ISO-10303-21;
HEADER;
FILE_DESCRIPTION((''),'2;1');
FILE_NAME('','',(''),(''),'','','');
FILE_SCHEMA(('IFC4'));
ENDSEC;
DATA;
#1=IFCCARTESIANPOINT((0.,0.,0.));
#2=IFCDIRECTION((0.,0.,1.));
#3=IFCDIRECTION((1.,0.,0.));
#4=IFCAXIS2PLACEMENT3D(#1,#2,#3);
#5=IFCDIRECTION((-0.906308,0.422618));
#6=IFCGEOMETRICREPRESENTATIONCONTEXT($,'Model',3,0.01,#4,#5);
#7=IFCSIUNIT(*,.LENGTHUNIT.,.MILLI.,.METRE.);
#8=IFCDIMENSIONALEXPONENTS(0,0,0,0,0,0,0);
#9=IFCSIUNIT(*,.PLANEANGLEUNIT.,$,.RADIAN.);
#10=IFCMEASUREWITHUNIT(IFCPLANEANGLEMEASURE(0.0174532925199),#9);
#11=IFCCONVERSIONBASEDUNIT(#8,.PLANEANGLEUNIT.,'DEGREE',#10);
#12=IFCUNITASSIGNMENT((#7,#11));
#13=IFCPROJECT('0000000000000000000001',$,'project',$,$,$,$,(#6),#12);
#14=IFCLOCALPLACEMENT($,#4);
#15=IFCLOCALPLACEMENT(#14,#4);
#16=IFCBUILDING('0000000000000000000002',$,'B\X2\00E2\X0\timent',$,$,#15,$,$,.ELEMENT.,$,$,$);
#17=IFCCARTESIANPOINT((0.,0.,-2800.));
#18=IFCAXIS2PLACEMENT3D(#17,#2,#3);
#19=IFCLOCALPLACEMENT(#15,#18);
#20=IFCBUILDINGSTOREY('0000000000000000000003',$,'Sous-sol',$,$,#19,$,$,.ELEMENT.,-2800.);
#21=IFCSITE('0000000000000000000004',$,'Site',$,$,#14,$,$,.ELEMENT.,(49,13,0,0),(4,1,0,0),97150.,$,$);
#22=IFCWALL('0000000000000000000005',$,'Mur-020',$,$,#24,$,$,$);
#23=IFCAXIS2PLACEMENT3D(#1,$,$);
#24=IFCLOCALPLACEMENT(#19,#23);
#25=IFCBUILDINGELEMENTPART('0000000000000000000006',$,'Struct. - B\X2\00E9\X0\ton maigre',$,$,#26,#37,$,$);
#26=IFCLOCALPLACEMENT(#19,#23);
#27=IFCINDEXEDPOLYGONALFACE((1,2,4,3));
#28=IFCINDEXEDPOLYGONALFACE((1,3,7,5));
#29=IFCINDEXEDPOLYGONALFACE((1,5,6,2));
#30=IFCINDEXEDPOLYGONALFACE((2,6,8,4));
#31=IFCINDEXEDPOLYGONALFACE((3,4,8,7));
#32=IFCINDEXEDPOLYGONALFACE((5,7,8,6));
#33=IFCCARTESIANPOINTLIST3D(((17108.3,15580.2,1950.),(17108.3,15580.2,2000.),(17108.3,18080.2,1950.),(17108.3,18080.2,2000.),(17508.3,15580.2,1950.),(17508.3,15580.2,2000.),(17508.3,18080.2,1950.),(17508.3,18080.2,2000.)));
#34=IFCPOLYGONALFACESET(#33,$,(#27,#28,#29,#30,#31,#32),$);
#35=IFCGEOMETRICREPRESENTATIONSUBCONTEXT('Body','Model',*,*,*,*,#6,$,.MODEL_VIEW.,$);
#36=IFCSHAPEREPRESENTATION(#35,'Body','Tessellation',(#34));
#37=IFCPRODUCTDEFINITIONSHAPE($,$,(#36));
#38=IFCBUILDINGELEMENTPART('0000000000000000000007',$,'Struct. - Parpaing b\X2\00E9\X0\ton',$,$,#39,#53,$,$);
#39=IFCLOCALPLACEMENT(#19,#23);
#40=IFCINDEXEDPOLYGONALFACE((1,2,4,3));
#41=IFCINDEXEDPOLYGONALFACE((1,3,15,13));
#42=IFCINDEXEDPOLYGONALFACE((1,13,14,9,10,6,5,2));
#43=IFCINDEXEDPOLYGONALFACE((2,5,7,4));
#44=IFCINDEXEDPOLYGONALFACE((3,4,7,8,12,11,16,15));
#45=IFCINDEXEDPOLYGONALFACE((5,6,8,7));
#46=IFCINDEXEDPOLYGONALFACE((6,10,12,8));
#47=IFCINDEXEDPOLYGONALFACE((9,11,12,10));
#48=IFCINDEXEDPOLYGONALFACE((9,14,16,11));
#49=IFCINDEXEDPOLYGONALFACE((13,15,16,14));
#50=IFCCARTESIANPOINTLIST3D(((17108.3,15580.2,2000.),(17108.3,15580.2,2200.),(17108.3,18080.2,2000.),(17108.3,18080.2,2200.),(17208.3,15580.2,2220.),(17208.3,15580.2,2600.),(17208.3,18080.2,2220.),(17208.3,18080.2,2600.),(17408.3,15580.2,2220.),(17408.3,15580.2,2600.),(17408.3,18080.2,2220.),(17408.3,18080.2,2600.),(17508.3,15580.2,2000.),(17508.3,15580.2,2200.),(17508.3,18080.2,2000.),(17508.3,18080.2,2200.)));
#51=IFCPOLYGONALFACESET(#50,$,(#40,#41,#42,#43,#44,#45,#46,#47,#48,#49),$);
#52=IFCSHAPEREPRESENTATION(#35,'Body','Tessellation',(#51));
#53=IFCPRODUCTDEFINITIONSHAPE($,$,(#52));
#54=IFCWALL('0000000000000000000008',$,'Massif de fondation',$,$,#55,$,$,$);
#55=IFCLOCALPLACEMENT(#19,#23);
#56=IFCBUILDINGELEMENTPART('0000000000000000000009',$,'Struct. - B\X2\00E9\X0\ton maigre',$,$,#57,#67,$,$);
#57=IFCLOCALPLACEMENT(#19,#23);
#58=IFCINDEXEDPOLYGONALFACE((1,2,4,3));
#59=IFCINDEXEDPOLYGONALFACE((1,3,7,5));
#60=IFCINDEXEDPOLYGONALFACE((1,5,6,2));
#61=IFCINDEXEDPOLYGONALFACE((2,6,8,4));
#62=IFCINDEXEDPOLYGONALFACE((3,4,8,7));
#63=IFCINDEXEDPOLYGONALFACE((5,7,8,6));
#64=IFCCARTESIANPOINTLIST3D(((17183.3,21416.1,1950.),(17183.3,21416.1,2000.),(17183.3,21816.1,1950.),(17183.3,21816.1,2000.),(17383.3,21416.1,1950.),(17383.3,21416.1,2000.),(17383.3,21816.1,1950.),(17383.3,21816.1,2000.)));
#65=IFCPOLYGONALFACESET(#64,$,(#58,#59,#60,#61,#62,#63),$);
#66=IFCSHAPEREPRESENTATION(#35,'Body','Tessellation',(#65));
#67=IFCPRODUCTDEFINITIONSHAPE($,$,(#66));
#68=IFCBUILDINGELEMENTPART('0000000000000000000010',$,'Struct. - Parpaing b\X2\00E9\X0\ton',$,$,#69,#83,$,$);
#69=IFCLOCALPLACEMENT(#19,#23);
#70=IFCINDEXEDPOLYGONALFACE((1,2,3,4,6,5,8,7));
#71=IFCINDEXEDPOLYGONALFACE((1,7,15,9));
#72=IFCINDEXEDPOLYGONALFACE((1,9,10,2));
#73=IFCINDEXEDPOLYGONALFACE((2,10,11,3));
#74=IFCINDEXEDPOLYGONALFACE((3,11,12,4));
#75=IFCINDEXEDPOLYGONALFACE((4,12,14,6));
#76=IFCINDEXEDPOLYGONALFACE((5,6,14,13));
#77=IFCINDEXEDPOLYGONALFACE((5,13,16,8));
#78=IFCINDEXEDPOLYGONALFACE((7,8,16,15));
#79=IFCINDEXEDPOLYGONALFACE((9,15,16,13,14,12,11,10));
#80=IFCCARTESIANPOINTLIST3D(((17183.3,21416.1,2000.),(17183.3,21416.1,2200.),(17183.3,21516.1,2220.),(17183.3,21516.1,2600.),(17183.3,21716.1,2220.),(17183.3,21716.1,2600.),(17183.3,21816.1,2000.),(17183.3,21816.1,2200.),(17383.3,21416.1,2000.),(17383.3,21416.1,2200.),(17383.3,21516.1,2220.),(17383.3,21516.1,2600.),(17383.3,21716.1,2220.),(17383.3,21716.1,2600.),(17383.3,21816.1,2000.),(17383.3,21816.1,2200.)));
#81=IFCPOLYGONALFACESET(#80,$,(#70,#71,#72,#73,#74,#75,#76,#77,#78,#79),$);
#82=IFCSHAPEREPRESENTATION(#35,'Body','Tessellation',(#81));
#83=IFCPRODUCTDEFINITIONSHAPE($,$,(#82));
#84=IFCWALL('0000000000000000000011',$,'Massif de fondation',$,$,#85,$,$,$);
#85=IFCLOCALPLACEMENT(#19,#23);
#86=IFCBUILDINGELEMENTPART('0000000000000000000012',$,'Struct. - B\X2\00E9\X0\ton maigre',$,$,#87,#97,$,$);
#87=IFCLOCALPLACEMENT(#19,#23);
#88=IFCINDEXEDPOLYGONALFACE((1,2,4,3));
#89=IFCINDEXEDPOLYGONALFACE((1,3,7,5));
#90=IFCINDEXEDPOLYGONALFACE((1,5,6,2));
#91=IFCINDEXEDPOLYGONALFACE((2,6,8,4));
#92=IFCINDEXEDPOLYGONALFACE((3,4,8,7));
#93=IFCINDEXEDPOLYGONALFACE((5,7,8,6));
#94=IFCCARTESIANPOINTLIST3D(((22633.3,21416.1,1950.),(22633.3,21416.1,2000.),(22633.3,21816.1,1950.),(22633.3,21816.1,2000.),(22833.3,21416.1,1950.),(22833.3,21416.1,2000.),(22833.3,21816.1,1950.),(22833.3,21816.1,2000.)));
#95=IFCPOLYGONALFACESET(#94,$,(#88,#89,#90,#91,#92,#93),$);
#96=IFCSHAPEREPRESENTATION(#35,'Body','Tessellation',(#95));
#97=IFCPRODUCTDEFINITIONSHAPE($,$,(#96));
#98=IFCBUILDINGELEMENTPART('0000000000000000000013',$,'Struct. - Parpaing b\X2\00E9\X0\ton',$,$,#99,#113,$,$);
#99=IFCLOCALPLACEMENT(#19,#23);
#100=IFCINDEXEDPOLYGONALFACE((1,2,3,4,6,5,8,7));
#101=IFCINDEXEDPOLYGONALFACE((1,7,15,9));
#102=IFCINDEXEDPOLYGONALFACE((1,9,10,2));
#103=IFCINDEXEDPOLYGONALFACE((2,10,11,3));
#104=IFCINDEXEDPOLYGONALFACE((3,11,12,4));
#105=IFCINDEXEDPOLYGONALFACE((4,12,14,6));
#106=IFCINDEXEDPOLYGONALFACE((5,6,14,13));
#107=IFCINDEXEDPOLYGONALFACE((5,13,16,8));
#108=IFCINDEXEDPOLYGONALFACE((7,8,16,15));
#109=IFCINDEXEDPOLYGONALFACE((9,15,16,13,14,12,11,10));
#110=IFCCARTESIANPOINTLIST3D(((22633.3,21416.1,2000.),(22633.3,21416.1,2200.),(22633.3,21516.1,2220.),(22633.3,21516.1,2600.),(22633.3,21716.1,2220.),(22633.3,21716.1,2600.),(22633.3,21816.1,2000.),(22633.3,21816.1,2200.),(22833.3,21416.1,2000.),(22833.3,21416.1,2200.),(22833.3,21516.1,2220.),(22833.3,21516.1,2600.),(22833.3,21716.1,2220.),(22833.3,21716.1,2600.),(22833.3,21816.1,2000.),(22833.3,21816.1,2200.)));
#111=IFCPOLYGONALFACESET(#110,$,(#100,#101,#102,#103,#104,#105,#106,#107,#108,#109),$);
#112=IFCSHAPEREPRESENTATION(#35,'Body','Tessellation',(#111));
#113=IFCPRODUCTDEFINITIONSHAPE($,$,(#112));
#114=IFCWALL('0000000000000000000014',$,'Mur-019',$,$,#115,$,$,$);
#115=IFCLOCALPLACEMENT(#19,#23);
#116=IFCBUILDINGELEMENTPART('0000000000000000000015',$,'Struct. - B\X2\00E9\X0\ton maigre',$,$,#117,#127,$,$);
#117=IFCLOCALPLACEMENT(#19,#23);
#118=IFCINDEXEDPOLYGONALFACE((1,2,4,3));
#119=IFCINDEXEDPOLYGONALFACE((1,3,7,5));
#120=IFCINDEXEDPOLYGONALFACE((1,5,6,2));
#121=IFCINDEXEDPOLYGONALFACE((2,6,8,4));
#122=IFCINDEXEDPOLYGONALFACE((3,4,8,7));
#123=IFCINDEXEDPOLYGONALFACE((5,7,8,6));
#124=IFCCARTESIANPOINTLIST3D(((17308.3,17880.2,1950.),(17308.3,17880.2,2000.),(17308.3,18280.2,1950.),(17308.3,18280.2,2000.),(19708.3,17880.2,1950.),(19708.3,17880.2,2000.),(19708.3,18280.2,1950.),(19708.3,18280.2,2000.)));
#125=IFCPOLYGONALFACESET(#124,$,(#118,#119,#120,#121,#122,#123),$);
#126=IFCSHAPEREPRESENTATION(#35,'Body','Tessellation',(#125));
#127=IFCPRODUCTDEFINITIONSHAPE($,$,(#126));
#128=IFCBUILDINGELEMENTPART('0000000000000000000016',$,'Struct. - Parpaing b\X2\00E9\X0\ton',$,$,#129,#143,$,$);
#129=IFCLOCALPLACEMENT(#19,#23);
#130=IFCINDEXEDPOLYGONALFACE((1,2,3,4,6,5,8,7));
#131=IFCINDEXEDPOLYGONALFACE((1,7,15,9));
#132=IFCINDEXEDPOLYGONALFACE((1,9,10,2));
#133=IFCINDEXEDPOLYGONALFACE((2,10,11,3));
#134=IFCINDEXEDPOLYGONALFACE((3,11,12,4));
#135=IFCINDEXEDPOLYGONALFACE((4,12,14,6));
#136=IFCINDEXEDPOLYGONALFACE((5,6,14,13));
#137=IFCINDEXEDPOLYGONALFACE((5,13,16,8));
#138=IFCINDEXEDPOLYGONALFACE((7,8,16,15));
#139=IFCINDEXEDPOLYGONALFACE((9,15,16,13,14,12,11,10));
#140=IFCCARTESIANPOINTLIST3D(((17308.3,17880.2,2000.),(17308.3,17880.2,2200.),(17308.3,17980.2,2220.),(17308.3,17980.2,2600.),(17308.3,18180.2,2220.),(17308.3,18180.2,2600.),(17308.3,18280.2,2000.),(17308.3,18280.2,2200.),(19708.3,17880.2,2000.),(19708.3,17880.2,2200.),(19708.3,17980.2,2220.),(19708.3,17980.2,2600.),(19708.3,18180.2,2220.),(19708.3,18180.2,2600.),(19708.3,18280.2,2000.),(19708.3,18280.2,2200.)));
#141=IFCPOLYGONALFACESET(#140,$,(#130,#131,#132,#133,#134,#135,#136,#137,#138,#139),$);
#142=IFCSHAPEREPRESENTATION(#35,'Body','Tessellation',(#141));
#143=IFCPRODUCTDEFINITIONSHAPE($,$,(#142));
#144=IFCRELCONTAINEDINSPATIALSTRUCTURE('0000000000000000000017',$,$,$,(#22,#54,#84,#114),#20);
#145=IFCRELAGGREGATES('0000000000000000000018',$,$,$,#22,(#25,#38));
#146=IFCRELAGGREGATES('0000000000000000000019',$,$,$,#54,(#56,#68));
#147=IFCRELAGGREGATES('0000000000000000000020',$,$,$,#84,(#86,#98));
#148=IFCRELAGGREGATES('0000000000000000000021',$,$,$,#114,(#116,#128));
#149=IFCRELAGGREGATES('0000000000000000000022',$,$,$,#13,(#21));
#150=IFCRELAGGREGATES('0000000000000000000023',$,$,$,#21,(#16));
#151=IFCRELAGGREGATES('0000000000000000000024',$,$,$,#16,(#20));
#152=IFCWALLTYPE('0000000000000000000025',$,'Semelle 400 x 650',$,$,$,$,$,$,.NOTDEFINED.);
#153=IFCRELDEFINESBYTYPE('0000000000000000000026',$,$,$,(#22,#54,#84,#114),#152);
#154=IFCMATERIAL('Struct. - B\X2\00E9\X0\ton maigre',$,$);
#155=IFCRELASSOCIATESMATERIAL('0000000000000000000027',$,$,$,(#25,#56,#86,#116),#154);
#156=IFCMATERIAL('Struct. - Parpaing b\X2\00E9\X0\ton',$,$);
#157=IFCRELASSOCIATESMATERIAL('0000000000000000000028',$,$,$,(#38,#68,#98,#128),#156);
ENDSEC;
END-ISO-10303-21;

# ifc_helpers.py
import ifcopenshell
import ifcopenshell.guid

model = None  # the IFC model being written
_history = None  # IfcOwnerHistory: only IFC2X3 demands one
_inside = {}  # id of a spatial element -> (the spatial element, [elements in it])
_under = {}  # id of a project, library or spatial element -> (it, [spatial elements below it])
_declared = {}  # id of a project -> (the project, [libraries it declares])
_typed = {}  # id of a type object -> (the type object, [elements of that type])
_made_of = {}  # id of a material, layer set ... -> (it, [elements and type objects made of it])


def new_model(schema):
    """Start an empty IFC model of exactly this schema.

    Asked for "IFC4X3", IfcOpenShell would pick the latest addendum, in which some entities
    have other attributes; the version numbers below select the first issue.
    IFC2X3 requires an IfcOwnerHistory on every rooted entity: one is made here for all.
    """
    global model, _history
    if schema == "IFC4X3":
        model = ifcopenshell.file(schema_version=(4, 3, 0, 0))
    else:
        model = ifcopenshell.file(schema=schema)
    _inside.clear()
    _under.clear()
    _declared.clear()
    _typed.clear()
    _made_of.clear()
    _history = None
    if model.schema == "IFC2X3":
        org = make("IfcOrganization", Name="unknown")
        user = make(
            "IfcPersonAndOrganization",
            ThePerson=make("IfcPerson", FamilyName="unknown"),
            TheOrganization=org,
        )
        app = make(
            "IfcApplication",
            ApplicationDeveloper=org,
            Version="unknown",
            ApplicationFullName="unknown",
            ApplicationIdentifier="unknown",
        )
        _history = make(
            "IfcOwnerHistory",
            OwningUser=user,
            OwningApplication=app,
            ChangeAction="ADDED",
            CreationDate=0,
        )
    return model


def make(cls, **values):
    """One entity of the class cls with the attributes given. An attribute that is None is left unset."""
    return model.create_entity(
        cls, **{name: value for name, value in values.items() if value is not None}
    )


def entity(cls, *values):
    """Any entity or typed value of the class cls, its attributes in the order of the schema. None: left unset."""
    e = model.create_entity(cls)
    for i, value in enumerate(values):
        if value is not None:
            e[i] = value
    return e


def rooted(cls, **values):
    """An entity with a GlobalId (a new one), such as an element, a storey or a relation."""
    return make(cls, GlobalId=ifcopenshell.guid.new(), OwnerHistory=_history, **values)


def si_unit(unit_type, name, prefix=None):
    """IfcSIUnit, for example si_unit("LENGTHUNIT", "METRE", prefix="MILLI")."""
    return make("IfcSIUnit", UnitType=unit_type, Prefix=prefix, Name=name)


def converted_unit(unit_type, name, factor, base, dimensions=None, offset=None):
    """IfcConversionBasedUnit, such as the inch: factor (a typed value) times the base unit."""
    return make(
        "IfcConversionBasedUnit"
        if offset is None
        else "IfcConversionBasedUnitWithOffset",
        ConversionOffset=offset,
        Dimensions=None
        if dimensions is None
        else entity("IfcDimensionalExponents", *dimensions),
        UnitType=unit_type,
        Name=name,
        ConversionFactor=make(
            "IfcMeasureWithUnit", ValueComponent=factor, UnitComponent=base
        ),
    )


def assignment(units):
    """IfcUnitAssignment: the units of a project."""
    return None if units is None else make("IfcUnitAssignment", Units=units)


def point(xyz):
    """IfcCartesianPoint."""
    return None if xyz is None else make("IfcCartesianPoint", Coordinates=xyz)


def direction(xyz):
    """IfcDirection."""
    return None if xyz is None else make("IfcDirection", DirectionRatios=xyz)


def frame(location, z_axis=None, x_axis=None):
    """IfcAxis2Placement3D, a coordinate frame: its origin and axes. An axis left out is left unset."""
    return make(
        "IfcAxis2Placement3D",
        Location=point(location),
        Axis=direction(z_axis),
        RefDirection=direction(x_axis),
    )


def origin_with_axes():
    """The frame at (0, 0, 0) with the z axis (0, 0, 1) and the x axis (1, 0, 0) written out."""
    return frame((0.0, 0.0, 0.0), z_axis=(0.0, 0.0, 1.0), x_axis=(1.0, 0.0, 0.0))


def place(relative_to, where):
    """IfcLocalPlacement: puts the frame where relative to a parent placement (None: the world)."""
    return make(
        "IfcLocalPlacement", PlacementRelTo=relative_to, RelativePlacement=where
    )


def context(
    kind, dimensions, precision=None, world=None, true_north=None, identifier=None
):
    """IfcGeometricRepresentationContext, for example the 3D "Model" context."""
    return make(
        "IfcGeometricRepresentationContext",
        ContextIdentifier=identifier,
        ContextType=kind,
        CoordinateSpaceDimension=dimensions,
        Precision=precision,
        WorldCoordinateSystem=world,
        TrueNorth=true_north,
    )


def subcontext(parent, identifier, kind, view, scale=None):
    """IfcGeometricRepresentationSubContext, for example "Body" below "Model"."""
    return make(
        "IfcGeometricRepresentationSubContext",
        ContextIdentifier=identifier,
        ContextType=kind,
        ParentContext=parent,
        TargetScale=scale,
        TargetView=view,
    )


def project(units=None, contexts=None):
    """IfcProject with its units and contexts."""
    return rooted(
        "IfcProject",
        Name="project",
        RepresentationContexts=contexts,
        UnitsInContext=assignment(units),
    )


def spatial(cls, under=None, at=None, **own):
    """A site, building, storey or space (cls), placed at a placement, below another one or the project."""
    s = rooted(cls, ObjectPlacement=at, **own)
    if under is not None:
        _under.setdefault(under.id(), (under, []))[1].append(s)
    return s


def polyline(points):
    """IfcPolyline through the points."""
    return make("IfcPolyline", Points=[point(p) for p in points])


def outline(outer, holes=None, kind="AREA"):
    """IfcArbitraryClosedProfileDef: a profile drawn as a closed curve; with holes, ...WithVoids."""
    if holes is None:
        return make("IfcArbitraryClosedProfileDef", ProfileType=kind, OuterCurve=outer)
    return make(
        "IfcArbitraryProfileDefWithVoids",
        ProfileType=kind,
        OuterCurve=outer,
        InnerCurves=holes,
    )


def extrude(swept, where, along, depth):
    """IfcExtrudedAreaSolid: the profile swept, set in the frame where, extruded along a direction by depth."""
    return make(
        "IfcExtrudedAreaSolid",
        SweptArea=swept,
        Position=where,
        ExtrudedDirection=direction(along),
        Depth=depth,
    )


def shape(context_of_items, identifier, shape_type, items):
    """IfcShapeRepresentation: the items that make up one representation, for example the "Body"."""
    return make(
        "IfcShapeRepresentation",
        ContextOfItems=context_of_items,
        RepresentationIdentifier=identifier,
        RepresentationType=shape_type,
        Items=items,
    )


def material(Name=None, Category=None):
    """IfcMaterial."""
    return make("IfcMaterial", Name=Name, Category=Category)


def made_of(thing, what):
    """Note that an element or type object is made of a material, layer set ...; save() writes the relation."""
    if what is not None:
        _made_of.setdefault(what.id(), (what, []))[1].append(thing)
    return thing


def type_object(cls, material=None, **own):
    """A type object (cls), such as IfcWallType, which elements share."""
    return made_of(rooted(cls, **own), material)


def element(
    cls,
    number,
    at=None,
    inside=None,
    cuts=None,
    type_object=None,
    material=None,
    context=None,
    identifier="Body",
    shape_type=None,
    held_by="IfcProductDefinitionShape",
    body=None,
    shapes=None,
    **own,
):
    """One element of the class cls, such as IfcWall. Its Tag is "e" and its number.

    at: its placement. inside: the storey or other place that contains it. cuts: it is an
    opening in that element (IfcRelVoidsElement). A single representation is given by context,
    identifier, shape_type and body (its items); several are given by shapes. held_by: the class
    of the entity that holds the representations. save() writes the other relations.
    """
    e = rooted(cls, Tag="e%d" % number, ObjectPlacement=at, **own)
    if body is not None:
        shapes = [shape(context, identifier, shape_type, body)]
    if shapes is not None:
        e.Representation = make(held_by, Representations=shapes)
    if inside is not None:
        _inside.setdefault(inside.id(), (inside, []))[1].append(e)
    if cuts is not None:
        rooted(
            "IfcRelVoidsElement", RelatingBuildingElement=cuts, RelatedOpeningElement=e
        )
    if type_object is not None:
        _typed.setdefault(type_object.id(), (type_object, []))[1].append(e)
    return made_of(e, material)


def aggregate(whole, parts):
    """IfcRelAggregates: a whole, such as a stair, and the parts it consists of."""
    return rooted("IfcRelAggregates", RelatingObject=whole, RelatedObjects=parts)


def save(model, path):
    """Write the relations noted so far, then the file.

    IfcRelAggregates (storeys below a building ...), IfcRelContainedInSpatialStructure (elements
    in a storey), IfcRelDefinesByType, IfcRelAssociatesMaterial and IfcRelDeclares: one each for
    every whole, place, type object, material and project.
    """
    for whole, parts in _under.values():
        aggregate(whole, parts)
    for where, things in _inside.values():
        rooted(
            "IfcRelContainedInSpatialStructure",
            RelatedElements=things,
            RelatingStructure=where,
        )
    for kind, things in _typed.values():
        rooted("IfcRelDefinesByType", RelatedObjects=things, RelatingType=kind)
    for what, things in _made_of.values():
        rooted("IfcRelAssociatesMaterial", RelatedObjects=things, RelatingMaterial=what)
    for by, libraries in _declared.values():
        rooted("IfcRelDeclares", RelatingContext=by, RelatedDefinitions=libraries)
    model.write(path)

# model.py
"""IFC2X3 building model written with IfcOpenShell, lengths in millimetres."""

from ifc_helpers import new_model, entity, si_unit, converted_unit, direction, frame, origin_with_axes, place, context, subcontext, project, spatial, polyline, outline, extrude, material, type_object, element, aggregate, save


model = new_model("IFC2X3")

# Units and contexts
model_context = context("Model", 3, precision=0.01, world=origin_with_axes(), true_north=direction((-0.906308, 0.422618)))
body_context = subcontext(model_context, "Body", "Model", "MODEL_VIEW")
ifc_project = project(units=[si_unit("LENGTHUNIT", "METRE", prefix="MILLI"), converted_unit("PLANEANGLEUNIT", "DEGREE", entity("IfcPlaneAngleMeasure", 0.0174532925199), si_unit("PLANEANGLEUNIT", "RADIAN"), dimensions=[0, 0, 0, 0, 0, 0, 0])], contexts=[model_context])

# Site, building, storey
site_placement = place(None, origin_with_axes())
site = spatial("IfcSite", under=ifc_project, at=site_placement, Name="Site", CompositionType="ELEMENT", RefLatitude=(49, 13, 0, 0), RefLongitude=(4, 1, 0, 0), RefElevation=97150.0)
building_placement = place(site_placement, origin_with_axes())
building = spatial("IfcBuilding", under=site, at=building_placement, Name="Bâtiment", CompositionType="ELEMENT")
storey_placement = place(building_placement, frame((0.0, 0.0, -2800.0), z_axis=(0.0, 0.0, 1.0), x_axis=(1.0, 0.0, 0.0)))
storey = spatial("IfcBuildingStorey", under=building, at=storey_placement, Name="Sous-sol", CompositionType="ELEMENT", Elevation=-2800.0)

# Walls, building element parts
ifc_material_1 = material(Name="Struct. - Béton maigre")
ifc_material_2 = material(Name="Struct. - Parpaing béton")
wall_type_1 = type_object("IfcWallType", Name="Semelle 400 x 650", PredefinedType="NOTDEFINED")
wall_1_placement = place(storey_placement, frame((17308.3, 18080.2, 2000.0), z_axis=(0.0, 0.0, 1.0), x_axis=(0.0, -1.0, 0.0)))
wall_1 = element("IfcWall", 1, at=wall_1_placement, inside=storey, type_object=wall_type_1, Name="Mur-020")
building_element_part_1_placement = place(wall_1_placement, origin_with_axes())
building_element_part_1 = element("IfcBuildingElementPart", 2, at=building_element_part_1_placement, material=ifc_material_1, Name="Struct. - Béton maigre", context=body_context, shape_type="SweptSolid", body=[
    extrude(outline(polyline([(-200.0, 0.0), (-200.0, -50.0), (200.0, -50.0), (200.0, 0.0), (-200.0, 0.0)])), frame((0.0, 0.0, 0.0), z_axis=(-1.0, 0.0, 0.0), x_axis=(0.0, -1.0, 0.0)), (0.0, 0.0, -1.0), 2500.0),
])
building_element_part_2_placement = place(wall_1_placement, origin_with_axes())
building_element_part_2 = element("IfcBuildingElementPart", 3, at=building_element_part_2_placement, material=ifc_material_2, Name="Struct. - Parpaing béton", context=body_context, shape_type="SweptSolid", body=[
    extrude(outline(polyline([(-200.0, 200.0), (-200.0, 0.0), (200.0, 0.0), (200.0, 200.0), (100.0, 220.0), (100.0, 600.0), (-100.0, 600.0), (-100.0, 220.0), (-200.0, 200.0)])), frame((0.0, 0.0, 0.0), z_axis=(-1.0, 0.0, 0.0), x_axis=(0.0, -1.0, 0.0)), (0.0, 0.0, -1.0), 2500.0),
])
aggregate(wall_1, [building_element_part_1, building_element_part_2])
wall_2_placement = place(storey_placement, frame((17183.3, 21616.1, 2000.0), z_axis=(0.0, 0.0, 1.0), x_axis=(1.0, 0.0, 0.0)))
wall_2 = element("IfcWall", 4, at=wall_2_placement, inside=storey, type_object=wall_type_1, Name="Massif de fondation")
building_element_part_3_placement = place(wall_2_placement, origin_with_axes())
building_element_part_3 = element("IfcBuildingElementPart", 5, at=building_element_part_3_placement, material=ifc_material_1, Name="Struct. - Béton maigre", context=body_context, shape_type="SweptSolid", body=[
    extrude(outline(polyline([(-200.0, 0.0), (-200.0, -50.0), (200.0, -50.0), (200.0, 0.0), (-200.0, 0.0)])), frame((0.0, 0.0, 0.0), z_axis=(-1.0, 0.0, 0.0), x_axis=(0.0, -1.0, 0.0)), (0.0, 0.0, -1.0), 200.0),
])
building_element_part_4_placement = place(wall_2_placement, origin_with_axes())
building_element_part_4 = element("IfcBuildingElementPart", 6, at=building_element_part_4_placement, material=ifc_material_2, Name="Struct. - Parpaing béton", context=body_context, shape_type="SweptSolid", body=[
    extrude(outline(polyline([(-200.0, 200.0), (-200.0, 0.0), (200.0, 0.0), (200.0, 200.0), (100.0, 220.0), (100.0, 600.0), (-100.0, 600.0), (-100.0, 220.0), (-200.0, 200.0)])), frame((0.0, 0.0, 0.0), z_axis=(-1.0, 0.0, 0.0), x_axis=(0.0, -1.0, 0.0)), (0.0, 0.0, -1.0), 200.0),
])
aggregate(wall_2, [building_element_part_3, building_element_part_4])
wall_3_placement = place(storey_placement, frame((22633.3, 21616.1, 2000.0), z_axis=(0.0, 0.0, 1.0), x_axis=(1.0, 0.0, 0.0)))
wall_3 = element("IfcWall", 7, at=wall_3_placement, inside=storey, type_object=wall_type_1, Name="Massif de fondation")
building_element_part_5_placement = place(wall_3_placement, origin_with_axes())
building_element_part_5 = element("IfcBuildingElementPart", 8, at=building_element_part_5_placement, material=ifc_material_1, Name="Struct. - Béton maigre", context=body_context, shape_type="SweptSolid", body=[
    extrude(outline(polyline([(-200.0, 0.0), (-200.0, -50.0), (200.0, -50.0), (200.0, 0.0), (-200.0, 0.0)])), frame((0.0, 0.0, 0.0), z_axis=(-1.0, 0.0, 0.0), x_axis=(0.0, -1.0, 0.0)), (0.0, 0.0, -1.0), 200.0),
])
building_element_part_6_placement = place(wall_3_placement, origin_with_axes())
building_element_part_6 = element("IfcBuildingElementPart", 9, at=building_element_part_6_placement, material=ifc_material_2, Name="Struct. - Parpaing béton", context=body_context, shape_type="SweptSolid", body=[
    extrude(outline(polyline([(-200.0, 200.0), (-200.0, 0.0), (200.0, 0.0), (200.0, 200.0), (100.0, 220.0), (100.0, 600.0), (-100.0, 600.0), (-100.0, 220.0), (-200.0, 200.0)])), frame((0.0, 0.0, 0.0), z_axis=(-1.0, 0.0, 0.0), x_axis=(0.0, -1.0, 0.0)), (0.0, 0.0, -1.0), 200.0),
])
aggregate(wall_3, [building_element_part_5, building_element_part_6])
wall_4_placement = place(storey_placement, frame((19708.3, 18080.2, 2000.0), z_axis=(0.0, 0.0, 1.0), x_axis=(-1.0, 0.0, 0.0)))
wall_4 = element("IfcWall", 10, at=wall_4_placement, inside=storey, type_object=wall_type_1, Name="Mur-019")
building_element_part_7_placement = place(wall_4_placement, origin_with_axes())
building_element_part_7 = element("IfcBuildingElementPart", 11, at=building_element_part_7_placement, material=ifc_material_1, Name="Struct. - Béton maigre", context=body_context, shape_type="SweptSolid", body=[
    extrude(outline(polyline([(-200.0, 0.0), (-200.0, -50.0), (200.0, -50.0), (200.0, 0.0), (-200.0, 0.0)])), frame((0.0, 0.0, 0.0), z_axis=(-1.0, 0.0, 0.0), x_axis=(0.0, -1.0, 0.0)), (0.0, 0.0, -1.0), 2400.0),
])
building_element_part_8_placement = place(wall_4_placement, origin_with_axes())
building_element_part_8 = element("IfcBuildingElementPart", 12, at=building_element_part_8_placement, material=ifc_material_2, Name="Struct. - Parpaing béton", context=body_context, shape_type="SweptSolid", body=[
    extrude(outline(polyline([(-200.0, 200.0), (-200.0, 0.0), (200.0, 0.0), (200.0, 200.0), (100.0, 220.0), (100.0, 600.0), (-100.0, 600.0), (-100.0, 220.0), (-200.0, 200.0)])), frame((0.0, 0.0, 0.0), z_axis=(-1.0, 0.0, 0.0), x_axis=(0.0, -1.0, 0.0)), (0.0, 0.0, -1.0), 2400.0),
])
aggregate(wall_4, [building_element_part_7, building_element_part_8])

save(model, "model.ifc")
